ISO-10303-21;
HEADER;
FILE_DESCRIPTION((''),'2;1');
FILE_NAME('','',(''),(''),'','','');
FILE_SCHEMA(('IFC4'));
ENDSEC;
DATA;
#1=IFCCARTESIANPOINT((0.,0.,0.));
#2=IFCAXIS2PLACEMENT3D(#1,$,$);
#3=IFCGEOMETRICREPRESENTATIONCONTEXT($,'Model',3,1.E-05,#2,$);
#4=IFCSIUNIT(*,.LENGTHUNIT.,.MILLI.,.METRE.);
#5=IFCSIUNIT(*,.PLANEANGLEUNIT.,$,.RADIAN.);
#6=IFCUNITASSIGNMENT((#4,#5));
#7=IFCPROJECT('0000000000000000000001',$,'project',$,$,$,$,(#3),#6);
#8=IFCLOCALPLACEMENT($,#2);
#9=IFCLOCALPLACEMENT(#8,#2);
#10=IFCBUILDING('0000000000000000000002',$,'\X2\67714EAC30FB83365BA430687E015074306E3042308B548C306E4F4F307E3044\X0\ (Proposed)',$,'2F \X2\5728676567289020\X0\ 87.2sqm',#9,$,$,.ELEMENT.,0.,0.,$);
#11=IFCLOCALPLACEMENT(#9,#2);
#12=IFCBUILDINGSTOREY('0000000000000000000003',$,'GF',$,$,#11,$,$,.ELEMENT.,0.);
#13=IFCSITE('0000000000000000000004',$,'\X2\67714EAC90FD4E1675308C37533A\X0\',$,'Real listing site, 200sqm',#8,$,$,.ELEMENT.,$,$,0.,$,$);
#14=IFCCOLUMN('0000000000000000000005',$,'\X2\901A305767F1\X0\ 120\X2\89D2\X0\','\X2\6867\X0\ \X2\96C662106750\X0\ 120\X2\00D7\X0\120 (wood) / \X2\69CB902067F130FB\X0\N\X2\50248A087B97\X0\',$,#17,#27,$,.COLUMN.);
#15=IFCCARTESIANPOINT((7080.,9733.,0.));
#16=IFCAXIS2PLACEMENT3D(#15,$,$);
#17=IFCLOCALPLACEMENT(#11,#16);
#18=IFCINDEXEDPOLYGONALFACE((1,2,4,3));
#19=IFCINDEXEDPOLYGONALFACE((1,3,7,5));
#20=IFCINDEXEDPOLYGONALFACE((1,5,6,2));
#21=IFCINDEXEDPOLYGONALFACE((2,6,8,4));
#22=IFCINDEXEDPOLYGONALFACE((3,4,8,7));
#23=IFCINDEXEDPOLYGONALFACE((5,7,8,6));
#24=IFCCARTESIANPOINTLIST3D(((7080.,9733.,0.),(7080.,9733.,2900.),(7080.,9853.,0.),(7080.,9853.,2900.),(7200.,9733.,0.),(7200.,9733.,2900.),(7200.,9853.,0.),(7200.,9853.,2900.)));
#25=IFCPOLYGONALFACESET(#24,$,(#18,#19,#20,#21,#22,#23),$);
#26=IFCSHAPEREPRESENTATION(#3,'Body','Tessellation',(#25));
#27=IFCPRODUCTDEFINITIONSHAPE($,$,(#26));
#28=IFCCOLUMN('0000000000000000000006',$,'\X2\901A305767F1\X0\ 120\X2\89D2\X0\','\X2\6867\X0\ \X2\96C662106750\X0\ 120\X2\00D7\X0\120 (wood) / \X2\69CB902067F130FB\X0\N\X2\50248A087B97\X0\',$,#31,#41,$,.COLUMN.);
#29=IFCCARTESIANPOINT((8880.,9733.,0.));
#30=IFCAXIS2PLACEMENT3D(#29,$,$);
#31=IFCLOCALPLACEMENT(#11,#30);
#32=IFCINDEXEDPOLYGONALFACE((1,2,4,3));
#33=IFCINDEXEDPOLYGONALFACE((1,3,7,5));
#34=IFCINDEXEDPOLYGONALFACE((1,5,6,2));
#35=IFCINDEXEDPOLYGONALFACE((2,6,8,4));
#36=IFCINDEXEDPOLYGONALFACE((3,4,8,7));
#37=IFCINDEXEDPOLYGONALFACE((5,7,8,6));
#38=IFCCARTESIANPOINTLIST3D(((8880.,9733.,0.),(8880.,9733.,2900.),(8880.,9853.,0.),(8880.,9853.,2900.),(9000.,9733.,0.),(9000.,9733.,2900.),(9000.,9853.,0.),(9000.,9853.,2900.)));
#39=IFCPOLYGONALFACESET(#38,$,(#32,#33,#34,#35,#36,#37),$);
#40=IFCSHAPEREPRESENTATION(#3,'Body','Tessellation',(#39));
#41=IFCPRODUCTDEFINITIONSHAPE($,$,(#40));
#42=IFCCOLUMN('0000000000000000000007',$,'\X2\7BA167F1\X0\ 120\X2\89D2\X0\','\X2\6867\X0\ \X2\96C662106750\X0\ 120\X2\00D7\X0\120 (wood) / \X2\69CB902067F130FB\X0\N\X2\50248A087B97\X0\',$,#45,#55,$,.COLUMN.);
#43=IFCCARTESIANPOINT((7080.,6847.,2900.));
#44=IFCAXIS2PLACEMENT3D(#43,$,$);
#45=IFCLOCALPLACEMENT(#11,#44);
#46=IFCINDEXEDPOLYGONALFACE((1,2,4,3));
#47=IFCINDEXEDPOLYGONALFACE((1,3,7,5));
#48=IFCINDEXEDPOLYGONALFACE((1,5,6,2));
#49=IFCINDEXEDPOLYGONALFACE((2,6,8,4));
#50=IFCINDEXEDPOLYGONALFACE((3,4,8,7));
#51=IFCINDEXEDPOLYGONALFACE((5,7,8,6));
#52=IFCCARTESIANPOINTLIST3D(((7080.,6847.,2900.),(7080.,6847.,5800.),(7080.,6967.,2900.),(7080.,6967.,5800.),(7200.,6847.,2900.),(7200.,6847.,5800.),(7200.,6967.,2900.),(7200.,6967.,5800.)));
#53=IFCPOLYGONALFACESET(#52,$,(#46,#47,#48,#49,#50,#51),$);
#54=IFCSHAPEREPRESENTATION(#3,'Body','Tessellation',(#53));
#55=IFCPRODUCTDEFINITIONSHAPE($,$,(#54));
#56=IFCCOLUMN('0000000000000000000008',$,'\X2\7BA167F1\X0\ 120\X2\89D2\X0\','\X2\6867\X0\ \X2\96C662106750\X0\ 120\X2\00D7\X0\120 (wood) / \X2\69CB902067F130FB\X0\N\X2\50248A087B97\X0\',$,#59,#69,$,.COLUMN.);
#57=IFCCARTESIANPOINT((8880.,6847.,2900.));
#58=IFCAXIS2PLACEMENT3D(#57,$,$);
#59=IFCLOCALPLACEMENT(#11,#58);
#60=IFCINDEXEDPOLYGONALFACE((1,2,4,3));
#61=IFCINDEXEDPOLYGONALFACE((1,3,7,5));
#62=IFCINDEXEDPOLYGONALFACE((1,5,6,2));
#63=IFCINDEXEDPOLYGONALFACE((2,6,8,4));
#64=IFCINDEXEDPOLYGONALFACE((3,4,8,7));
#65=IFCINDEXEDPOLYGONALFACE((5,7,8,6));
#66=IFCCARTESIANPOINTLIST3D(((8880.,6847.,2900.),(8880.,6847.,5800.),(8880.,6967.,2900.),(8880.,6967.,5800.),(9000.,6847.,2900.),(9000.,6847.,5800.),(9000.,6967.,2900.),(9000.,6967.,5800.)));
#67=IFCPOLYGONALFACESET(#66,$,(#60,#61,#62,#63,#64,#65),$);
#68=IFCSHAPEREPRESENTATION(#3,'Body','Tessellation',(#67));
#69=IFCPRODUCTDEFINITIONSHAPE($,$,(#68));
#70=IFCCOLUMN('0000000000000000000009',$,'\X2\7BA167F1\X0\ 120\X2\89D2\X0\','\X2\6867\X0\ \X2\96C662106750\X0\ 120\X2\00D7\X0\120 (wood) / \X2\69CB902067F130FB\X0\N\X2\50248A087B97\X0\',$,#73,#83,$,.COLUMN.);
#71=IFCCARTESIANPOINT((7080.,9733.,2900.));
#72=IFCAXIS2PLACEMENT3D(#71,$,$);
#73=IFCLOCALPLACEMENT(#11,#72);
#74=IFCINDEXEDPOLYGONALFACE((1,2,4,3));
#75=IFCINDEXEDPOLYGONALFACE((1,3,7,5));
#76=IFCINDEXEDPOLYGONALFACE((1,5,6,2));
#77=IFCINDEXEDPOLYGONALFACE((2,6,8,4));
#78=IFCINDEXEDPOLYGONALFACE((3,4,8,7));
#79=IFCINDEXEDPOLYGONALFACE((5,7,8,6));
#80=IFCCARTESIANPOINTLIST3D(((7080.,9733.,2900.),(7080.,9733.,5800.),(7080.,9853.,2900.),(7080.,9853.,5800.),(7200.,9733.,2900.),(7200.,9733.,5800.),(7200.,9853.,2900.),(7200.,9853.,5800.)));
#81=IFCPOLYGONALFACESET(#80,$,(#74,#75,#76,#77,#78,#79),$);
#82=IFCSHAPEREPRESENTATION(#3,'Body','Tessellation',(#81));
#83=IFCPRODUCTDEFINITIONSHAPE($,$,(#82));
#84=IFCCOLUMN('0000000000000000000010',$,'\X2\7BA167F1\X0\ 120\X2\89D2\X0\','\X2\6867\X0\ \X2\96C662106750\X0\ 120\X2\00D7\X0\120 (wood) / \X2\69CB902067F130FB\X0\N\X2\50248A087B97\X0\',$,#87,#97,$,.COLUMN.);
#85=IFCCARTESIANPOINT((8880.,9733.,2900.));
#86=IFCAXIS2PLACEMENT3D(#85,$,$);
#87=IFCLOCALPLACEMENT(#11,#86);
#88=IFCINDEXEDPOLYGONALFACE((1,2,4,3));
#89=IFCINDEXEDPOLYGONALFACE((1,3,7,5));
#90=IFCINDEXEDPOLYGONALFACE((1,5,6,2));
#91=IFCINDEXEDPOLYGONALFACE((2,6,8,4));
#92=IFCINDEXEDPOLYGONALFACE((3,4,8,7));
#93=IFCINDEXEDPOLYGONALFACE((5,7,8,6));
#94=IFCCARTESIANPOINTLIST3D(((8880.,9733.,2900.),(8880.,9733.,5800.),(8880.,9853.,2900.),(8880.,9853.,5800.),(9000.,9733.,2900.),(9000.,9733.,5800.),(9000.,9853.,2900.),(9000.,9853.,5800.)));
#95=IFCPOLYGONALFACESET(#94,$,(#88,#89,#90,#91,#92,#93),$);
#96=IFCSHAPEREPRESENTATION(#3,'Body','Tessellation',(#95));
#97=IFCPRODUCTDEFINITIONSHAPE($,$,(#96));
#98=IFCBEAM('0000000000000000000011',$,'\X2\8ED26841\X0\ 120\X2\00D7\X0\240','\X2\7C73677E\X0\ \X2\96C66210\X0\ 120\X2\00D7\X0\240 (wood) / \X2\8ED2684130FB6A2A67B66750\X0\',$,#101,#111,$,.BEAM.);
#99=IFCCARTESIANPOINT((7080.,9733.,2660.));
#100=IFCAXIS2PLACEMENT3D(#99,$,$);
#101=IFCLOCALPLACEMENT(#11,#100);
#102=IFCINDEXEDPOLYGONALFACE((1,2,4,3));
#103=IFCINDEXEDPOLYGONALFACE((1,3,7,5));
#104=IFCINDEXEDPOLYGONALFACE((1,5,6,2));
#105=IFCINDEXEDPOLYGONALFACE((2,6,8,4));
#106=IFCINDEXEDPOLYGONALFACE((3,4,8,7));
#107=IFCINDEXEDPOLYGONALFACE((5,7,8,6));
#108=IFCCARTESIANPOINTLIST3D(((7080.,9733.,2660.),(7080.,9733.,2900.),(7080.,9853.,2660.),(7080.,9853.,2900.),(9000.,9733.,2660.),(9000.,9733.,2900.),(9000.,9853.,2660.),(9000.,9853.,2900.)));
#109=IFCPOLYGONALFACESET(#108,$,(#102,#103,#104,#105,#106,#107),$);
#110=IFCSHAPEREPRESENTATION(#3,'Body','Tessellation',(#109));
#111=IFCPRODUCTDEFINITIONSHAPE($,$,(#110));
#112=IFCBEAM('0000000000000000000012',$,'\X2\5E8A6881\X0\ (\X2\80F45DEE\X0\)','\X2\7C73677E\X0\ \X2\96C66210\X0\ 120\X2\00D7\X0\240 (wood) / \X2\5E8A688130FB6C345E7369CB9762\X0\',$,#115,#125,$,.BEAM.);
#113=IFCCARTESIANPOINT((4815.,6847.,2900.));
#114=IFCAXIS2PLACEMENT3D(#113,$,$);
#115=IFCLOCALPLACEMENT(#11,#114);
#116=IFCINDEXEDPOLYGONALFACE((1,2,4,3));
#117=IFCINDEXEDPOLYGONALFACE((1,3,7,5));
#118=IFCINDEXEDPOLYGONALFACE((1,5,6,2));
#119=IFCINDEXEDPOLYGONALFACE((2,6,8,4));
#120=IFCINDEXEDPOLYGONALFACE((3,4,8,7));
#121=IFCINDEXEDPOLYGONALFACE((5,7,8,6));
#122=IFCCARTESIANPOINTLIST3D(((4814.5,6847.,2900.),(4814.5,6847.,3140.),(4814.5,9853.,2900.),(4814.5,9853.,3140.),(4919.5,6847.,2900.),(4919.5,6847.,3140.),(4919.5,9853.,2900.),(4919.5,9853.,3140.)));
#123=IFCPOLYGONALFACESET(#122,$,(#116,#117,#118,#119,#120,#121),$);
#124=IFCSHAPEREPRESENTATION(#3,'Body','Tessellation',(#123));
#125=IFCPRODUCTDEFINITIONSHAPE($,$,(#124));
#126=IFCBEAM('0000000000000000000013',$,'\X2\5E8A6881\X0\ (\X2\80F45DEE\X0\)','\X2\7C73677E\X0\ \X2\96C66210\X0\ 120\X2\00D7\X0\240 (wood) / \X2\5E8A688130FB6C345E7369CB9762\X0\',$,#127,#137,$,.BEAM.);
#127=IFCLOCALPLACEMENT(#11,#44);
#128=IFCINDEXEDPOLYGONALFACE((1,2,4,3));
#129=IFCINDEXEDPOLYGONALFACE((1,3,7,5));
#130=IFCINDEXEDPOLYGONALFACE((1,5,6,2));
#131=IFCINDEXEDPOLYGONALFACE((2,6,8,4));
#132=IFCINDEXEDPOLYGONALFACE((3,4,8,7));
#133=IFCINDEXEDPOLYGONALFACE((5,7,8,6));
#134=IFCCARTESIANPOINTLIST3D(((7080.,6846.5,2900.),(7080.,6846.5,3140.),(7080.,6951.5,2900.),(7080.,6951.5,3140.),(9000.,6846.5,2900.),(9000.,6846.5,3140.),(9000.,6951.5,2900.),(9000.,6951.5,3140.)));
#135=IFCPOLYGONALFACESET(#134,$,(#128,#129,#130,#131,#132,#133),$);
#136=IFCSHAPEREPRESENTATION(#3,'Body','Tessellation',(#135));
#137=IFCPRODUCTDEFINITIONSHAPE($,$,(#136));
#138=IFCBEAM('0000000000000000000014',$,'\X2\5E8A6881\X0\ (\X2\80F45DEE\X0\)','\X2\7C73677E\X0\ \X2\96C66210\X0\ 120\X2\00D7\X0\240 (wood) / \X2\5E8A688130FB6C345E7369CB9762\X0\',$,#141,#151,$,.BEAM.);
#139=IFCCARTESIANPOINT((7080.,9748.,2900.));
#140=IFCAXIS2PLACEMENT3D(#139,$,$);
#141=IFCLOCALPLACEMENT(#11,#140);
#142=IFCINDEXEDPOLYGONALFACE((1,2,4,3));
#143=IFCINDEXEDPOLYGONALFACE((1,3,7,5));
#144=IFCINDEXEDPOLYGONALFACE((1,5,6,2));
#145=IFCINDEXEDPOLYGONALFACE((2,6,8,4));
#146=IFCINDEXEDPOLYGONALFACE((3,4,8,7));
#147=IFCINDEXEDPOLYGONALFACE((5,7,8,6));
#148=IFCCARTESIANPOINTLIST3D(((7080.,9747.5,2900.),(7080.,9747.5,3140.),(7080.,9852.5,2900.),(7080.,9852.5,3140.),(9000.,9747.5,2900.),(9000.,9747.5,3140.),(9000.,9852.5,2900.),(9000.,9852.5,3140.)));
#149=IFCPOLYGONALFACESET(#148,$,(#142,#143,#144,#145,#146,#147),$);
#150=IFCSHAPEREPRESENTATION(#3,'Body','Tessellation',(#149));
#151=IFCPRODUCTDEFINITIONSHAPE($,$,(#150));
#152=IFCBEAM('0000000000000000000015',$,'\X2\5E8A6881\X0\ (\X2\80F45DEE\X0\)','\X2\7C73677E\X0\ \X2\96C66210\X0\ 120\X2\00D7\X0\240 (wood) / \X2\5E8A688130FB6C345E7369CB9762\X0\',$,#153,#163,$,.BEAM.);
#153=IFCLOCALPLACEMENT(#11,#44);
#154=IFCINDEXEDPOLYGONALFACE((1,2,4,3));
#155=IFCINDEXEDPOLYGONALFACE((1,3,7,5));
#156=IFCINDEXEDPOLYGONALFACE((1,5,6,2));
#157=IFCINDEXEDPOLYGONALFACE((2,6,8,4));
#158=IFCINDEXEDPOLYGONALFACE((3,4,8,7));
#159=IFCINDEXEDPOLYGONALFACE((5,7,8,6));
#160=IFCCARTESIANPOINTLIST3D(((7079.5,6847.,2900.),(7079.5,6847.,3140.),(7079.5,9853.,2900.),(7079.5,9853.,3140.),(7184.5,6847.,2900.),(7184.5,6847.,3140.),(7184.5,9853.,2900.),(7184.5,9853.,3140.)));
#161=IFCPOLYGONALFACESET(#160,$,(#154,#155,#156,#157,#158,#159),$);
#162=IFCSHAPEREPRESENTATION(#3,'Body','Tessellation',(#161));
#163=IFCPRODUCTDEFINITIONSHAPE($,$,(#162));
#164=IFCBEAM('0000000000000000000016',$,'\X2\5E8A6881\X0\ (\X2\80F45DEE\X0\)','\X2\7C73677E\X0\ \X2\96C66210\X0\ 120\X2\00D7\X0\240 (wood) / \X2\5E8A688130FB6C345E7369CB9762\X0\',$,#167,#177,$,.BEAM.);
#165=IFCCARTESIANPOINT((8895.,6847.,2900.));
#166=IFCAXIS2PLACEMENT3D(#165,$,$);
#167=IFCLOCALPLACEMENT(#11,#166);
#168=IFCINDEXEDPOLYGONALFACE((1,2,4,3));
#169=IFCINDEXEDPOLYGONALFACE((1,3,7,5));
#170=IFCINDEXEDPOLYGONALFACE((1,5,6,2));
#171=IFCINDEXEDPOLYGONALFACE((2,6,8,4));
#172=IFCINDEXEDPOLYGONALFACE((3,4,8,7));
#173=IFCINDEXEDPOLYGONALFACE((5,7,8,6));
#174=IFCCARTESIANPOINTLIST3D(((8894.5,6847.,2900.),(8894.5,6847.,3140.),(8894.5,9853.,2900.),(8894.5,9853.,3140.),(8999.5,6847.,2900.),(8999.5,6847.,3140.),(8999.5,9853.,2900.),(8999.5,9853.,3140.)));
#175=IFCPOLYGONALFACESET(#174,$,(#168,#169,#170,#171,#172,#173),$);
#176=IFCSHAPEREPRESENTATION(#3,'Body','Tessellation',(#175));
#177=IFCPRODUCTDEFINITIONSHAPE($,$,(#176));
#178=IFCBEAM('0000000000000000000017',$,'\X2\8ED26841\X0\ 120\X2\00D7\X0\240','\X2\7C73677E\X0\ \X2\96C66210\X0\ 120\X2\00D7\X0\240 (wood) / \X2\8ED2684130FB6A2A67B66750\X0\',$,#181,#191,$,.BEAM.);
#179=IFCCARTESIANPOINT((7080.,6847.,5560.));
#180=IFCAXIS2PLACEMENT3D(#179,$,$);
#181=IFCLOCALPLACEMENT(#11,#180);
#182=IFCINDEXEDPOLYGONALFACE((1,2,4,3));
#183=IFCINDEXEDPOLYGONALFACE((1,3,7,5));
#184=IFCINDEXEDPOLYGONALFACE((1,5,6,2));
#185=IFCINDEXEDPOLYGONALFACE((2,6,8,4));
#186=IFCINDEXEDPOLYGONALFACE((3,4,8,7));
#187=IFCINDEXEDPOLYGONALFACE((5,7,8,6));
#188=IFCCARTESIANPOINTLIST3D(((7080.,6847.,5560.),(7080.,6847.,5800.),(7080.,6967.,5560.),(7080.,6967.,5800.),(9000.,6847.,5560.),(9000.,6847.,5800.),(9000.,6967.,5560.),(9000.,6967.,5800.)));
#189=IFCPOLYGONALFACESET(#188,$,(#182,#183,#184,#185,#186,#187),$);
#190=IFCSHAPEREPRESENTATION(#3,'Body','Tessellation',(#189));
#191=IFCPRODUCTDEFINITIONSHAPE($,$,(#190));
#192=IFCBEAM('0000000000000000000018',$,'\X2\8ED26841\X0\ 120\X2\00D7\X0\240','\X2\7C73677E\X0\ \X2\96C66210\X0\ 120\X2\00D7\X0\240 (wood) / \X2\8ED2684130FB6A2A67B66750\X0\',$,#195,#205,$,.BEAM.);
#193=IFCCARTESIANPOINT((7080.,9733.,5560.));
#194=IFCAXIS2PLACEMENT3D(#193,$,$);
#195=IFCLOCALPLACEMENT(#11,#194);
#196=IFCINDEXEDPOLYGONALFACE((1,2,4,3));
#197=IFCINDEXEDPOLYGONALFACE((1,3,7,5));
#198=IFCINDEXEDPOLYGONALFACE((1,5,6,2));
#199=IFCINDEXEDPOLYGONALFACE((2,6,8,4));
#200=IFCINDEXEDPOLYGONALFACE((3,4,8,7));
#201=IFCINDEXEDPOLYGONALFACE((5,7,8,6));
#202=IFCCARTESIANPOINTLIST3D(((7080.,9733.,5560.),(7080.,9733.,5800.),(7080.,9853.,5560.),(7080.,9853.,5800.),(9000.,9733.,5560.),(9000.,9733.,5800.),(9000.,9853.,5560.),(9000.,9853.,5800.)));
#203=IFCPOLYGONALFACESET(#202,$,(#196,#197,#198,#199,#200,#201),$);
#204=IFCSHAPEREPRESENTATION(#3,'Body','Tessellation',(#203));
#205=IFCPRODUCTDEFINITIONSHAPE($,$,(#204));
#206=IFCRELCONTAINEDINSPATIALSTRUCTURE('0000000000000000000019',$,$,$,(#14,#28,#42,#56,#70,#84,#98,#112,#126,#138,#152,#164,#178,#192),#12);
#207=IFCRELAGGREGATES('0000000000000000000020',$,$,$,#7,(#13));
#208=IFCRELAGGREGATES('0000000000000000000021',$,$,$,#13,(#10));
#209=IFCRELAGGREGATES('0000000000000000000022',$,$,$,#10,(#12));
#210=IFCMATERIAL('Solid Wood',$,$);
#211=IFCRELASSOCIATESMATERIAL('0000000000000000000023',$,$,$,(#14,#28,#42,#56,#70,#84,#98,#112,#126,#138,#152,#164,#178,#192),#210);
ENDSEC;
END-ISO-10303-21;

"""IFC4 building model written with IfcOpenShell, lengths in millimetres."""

from ifc_helpers import new_model, si_unit, frame, frame_2d, origin, place, context, project, spatial, rectangle, extrude, material, element, save


model = new_model("IFC4")

# Units and contexts
model_context = context("Model", 3, precision=1e-05, world=origin())
ifc_project = project(units=[si_unit("LENGTHUNIT", "METRE", prefix="MILLI"), si_unit("PLANEANGLEUNIT", "RADIAN")], contexts=[model_context])

# Site, building, storey
site_placement = place(None, origin())
site = spatial("IfcSite", under=ifc_project, at=site_placement, Name="東京都世田谷区", ObjectType="Real listing site, 200sqm", CompositionType="ELEMENT", RefElevation=0.0)
building_placement = place(site_placement, origin())
building = spatial("IfcBuilding", under=site, at=building_placement, Name="東京・茶室と縁側のある和の住まい (Proposed)", ObjectType="2F 在来木造 87.2sqm", CompositionType="ELEMENT", ElevationOfRefHeight=0.0, ElevationOfTerrain=0.0)
storey_placement = place(building_placement, origin())
storey = spatial("IfcBuildingStorey", under=building, at=storey_placement, Name="GF", CompositionType="ELEMENT", Elevation=0.0)

# Columns
ifc_material_1 = material(Name="Solid Wood")
column_1_placement = place(storey_placement, frame((7080.0, 9733.0, 0.0)))
element("IfcColumn", 1, at=column_1_placement, inside=storey, material=ifc_material_1, Name="通し柱 120角", Description="桧 集成材 120×120 (wood) / 構造柱・N値計算", PredefinedType="COLUMN", context=model_context, shape_type="SweptSolid", body=[
    extrude(rectangle(XDim=120.0, YDim=120.0, at=frame_2d((60.0, 60.0))), frame((7080.0, 9733.0, 0.0)), (0.0, 0.0, 1.0), 2900.0),
])
column_2_placement = place(storey_placement, frame((8880.0, 9733.0, 0.0)))
element("IfcColumn", 2, at=column_2_placement, inside=storey, material=ifc_material_1, Name="通し柱 120角", Description="桧 集成材 120×120 (wood) / 構造柱・N値計算", PredefinedType="COLUMN", context=model_context, shape_type="SweptSolid", body=[
    extrude(rectangle(XDim=120.0, YDim=120.0, at=frame_2d((60.0, 60.0))), frame((8880.0, 9733.0, 0.0)), (0.0, 0.0, 1.0), 2900.0),
])
column_3_placement = place(storey_placement, frame((7080.0, 6847.0, 2900.0)))
element("IfcColumn", 3, at=column_3_placement, inside=storey, material=ifc_material_1, Name="管柱 120角", Description="桧 集成材 120×120 (wood) / 構造柱・N値計算", PredefinedType="COLUMN", context=model_context, shape_type="SweptSolid", body=[
    extrude(rectangle(XDim=120.0, YDim=120.0, at=frame_2d((60.0, 60.0))), frame((7080.0, 6847.0, 2900.0)), (0.0, 0.0, 1.0), 2900.0),
])
column_4_placement = place(storey_placement, frame((8880.0, 6847.0, 2900.0)))
element("IfcColumn", 4, at=column_4_placement, inside=storey, material=ifc_material_1, Name="管柱 120角", Description="桧 集成材 120×120 (wood) / 構造柱・N値計算", PredefinedType="COLUMN", context=model_context, shape_type="SweptSolid", body=[
    extrude(rectangle(XDim=120.0, YDim=120.0, at=frame_2d((60.0, 60.0))), frame((8880.0, 6847.0, 2900.0)), (0.0, 0.0, 1.0), 2900.0),
])
column_5_placement = place(storey_placement, frame((7080.0, 9733.0, 2900.0)))
element("IfcColumn", 5, at=column_5_placement, inside=storey, material=ifc_material_1, Name="管柱 120角", Description="桧 集成材 120×120 (wood) / 構造柱・N値計算", PredefinedType="COLUMN", context=model_context, shape_type="SweptSolid", body=[
    extrude(rectangle(XDim=120.0, YDim=120.0, at=frame_2d((60.0, 60.0))), frame((7080.0, 9733.0, 2900.0)), (0.0, 0.0, 1.0), 2900.0),
])
column_6_placement = place(storey_placement, frame((8880.0, 9733.0, 2900.0)))
element("IfcColumn", 6, at=column_6_placement, inside=storey, material=ifc_material_1, Name="管柱 120角", Description="桧 集成材 120×120 (wood) / 構造柱・N値計算", PredefinedType="COLUMN", context=model_context, shape_type="SweptSolid", body=[
    extrude(rectangle(XDim=120.0, YDim=120.0, at=frame_2d((60.0, 60.0))), frame((8880.0, 9733.0, 2900.0)), (0.0, 0.0, 1.0), 2900.0),
])

# Beams
beam_1_placement = place(storey_placement, frame((7080.0, 9733.0, 2660.0)))
element("IfcBeam", 7, at=beam_1_placement, inside=storey, material=ifc_material_1, Name="軒桁 120×240", Description="米松 集成 120×240 (wood) / 軒桁・横架材", PredefinedType="BEAM", context=model_context, shape_type="SweptSolid", body=[
    extrude(rectangle(XDim=1920.0, YDim=120.0, at=frame_2d((960.0, 60.0))), frame((7080.0, 9733.0, 2660.0)), (0.0, 0.0, 1.0), 240.0),
])
beam_2_placement = place(storey_placement, frame((4815.0, 6847.0, 2900.0)))
element("IfcBeam", 8, at=beam_2_placement, inside=storey, material=ifc_material_1, Name="床梁 (胴差)", Description="米松 集成 120×240 (wood) / 床梁・水平構面", PredefinedType="BEAM", context=model_context, shape_type="SweptSolid", body=[
    extrude(rectangle(XDim=105.0, YDim=3006.0, at=frame_2d((52.0, 1503.0))), frame((4815.0, 6847.0, 2900.0)), (0.0, 0.0, 1.0), 240.0),
])
beam_3_placement = place(storey_placement, frame((7080.0, 6847.0, 2900.0)))
element("IfcBeam", 9, at=beam_3_placement, inside=storey, material=ifc_material_1, Name="床梁 (胴差)", Description="米松 集成 120×240 (wood) / 床梁・水平構面", PredefinedType="BEAM", context=model_context, shape_type="SweptSolid", body=[
    extrude(rectangle(XDim=1920.0, YDim=105.0, at=frame_2d((960.0, 52.0))), frame((7080.0, 6847.0, 2900.0)), (0.0, 0.0, 1.0), 240.0),
])
beam_4_placement = place(storey_placement, frame((7080.0, 9748.0, 2900.0)))
element("IfcBeam", 10, at=beam_4_placement, inside=storey, material=ifc_material_1, Name="床梁 (胴差)", Description="米松 集成 120×240 (wood) / 床梁・水平構面", PredefinedType="BEAM", context=model_context, shape_type="SweptSolid", body=[
    extrude(rectangle(XDim=1920.0, YDim=105.0, at=frame_2d((960.0, 52.0))), frame((7080.0, 9748.0, 2900.0)), (0.0, 0.0, 1.0), 240.0),
])
beam_5_placement = place(storey_placement, frame((7080.0, 6847.0, 2900.0)))
element("IfcBeam", 11, at=beam_5_placement, inside=storey, material=ifc_material_1, Name="床梁 (胴差)", Description="米松 集成 120×240 (wood) / 床梁・水平構面", PredefinedType="BEAM", context=model_context, shape_type="SweptSolid", body=[
    extrude(rectangle(XDim=105.0, YDim=3006.0, at=frame_2d((52.0, 1503.0))), frame((7080.0, 6847.0, 2900.0)), (0.0, 0.0, 1.0), 240.0),
])
beam_6_placement = place(storey_placement, frame((8895.0, 6847.0, 2900.0)))
element("IfcBeam", 12, at=beam_6_placement, inside=storey, material=ifc_material_1, Name="床梁 (胴差)", Description="米松 集成 120×240 (wood) / 床梁・水平構面", PredefinedType="BEAM", context=model_context, shape_type="SweptSolid", body=[
    extrude(rectangle(XDim=105.0, YDim=3006.0, at=frame_2d((52.0, 1503.0))), frame((8895.0, 6847.0, 2900.0)), (0.0, 0.0, 1.0), 240.0),
])
beam_7_placement = place(storey_placement, frame((7080.0, 6847.0, 5560.0)))
element("IfcBeam", 13, at=beam_7_placement, inside=storey, material=ifc_material_1, Name="軒桁 120×240", Description="米松 集成 120×240 (wood) / 軒桁・横架材", PredefinedType="BEAM", context=model_context, shape_type="SweptSolid", body=[
    extrude(rectangle(XDim=1920.0, YDim=120.0, at=frame_2d((960.0, 60.0))), frame((7080.0, 6847.0, 5560.0)), (0.0, 0.0, 1.0), 240.0),
])
beam_8_placement = place(storey_placement, frame((7080.0, 9733.0, 5560.0)))
element("IfcBeam", 14, at=beam_8_placement, inside=storey, material=ifc_material_1, Name="軒桁 120×240", Description="米松 集成 120×240 (wood) / 軒桁・横架材", PredefinedType="BEAM", context=model_context, shape_type="SweptSolid", body=[
    extrude(rectangle(XDim=1920.0, YDim=120.0, at=frame_2d((960.0, 60.0))), frame((7080.0, 9733.0, 5560.0)), (0.0, 0.0, 1.0), 240.0),
])

save(model, "model.ifc")
